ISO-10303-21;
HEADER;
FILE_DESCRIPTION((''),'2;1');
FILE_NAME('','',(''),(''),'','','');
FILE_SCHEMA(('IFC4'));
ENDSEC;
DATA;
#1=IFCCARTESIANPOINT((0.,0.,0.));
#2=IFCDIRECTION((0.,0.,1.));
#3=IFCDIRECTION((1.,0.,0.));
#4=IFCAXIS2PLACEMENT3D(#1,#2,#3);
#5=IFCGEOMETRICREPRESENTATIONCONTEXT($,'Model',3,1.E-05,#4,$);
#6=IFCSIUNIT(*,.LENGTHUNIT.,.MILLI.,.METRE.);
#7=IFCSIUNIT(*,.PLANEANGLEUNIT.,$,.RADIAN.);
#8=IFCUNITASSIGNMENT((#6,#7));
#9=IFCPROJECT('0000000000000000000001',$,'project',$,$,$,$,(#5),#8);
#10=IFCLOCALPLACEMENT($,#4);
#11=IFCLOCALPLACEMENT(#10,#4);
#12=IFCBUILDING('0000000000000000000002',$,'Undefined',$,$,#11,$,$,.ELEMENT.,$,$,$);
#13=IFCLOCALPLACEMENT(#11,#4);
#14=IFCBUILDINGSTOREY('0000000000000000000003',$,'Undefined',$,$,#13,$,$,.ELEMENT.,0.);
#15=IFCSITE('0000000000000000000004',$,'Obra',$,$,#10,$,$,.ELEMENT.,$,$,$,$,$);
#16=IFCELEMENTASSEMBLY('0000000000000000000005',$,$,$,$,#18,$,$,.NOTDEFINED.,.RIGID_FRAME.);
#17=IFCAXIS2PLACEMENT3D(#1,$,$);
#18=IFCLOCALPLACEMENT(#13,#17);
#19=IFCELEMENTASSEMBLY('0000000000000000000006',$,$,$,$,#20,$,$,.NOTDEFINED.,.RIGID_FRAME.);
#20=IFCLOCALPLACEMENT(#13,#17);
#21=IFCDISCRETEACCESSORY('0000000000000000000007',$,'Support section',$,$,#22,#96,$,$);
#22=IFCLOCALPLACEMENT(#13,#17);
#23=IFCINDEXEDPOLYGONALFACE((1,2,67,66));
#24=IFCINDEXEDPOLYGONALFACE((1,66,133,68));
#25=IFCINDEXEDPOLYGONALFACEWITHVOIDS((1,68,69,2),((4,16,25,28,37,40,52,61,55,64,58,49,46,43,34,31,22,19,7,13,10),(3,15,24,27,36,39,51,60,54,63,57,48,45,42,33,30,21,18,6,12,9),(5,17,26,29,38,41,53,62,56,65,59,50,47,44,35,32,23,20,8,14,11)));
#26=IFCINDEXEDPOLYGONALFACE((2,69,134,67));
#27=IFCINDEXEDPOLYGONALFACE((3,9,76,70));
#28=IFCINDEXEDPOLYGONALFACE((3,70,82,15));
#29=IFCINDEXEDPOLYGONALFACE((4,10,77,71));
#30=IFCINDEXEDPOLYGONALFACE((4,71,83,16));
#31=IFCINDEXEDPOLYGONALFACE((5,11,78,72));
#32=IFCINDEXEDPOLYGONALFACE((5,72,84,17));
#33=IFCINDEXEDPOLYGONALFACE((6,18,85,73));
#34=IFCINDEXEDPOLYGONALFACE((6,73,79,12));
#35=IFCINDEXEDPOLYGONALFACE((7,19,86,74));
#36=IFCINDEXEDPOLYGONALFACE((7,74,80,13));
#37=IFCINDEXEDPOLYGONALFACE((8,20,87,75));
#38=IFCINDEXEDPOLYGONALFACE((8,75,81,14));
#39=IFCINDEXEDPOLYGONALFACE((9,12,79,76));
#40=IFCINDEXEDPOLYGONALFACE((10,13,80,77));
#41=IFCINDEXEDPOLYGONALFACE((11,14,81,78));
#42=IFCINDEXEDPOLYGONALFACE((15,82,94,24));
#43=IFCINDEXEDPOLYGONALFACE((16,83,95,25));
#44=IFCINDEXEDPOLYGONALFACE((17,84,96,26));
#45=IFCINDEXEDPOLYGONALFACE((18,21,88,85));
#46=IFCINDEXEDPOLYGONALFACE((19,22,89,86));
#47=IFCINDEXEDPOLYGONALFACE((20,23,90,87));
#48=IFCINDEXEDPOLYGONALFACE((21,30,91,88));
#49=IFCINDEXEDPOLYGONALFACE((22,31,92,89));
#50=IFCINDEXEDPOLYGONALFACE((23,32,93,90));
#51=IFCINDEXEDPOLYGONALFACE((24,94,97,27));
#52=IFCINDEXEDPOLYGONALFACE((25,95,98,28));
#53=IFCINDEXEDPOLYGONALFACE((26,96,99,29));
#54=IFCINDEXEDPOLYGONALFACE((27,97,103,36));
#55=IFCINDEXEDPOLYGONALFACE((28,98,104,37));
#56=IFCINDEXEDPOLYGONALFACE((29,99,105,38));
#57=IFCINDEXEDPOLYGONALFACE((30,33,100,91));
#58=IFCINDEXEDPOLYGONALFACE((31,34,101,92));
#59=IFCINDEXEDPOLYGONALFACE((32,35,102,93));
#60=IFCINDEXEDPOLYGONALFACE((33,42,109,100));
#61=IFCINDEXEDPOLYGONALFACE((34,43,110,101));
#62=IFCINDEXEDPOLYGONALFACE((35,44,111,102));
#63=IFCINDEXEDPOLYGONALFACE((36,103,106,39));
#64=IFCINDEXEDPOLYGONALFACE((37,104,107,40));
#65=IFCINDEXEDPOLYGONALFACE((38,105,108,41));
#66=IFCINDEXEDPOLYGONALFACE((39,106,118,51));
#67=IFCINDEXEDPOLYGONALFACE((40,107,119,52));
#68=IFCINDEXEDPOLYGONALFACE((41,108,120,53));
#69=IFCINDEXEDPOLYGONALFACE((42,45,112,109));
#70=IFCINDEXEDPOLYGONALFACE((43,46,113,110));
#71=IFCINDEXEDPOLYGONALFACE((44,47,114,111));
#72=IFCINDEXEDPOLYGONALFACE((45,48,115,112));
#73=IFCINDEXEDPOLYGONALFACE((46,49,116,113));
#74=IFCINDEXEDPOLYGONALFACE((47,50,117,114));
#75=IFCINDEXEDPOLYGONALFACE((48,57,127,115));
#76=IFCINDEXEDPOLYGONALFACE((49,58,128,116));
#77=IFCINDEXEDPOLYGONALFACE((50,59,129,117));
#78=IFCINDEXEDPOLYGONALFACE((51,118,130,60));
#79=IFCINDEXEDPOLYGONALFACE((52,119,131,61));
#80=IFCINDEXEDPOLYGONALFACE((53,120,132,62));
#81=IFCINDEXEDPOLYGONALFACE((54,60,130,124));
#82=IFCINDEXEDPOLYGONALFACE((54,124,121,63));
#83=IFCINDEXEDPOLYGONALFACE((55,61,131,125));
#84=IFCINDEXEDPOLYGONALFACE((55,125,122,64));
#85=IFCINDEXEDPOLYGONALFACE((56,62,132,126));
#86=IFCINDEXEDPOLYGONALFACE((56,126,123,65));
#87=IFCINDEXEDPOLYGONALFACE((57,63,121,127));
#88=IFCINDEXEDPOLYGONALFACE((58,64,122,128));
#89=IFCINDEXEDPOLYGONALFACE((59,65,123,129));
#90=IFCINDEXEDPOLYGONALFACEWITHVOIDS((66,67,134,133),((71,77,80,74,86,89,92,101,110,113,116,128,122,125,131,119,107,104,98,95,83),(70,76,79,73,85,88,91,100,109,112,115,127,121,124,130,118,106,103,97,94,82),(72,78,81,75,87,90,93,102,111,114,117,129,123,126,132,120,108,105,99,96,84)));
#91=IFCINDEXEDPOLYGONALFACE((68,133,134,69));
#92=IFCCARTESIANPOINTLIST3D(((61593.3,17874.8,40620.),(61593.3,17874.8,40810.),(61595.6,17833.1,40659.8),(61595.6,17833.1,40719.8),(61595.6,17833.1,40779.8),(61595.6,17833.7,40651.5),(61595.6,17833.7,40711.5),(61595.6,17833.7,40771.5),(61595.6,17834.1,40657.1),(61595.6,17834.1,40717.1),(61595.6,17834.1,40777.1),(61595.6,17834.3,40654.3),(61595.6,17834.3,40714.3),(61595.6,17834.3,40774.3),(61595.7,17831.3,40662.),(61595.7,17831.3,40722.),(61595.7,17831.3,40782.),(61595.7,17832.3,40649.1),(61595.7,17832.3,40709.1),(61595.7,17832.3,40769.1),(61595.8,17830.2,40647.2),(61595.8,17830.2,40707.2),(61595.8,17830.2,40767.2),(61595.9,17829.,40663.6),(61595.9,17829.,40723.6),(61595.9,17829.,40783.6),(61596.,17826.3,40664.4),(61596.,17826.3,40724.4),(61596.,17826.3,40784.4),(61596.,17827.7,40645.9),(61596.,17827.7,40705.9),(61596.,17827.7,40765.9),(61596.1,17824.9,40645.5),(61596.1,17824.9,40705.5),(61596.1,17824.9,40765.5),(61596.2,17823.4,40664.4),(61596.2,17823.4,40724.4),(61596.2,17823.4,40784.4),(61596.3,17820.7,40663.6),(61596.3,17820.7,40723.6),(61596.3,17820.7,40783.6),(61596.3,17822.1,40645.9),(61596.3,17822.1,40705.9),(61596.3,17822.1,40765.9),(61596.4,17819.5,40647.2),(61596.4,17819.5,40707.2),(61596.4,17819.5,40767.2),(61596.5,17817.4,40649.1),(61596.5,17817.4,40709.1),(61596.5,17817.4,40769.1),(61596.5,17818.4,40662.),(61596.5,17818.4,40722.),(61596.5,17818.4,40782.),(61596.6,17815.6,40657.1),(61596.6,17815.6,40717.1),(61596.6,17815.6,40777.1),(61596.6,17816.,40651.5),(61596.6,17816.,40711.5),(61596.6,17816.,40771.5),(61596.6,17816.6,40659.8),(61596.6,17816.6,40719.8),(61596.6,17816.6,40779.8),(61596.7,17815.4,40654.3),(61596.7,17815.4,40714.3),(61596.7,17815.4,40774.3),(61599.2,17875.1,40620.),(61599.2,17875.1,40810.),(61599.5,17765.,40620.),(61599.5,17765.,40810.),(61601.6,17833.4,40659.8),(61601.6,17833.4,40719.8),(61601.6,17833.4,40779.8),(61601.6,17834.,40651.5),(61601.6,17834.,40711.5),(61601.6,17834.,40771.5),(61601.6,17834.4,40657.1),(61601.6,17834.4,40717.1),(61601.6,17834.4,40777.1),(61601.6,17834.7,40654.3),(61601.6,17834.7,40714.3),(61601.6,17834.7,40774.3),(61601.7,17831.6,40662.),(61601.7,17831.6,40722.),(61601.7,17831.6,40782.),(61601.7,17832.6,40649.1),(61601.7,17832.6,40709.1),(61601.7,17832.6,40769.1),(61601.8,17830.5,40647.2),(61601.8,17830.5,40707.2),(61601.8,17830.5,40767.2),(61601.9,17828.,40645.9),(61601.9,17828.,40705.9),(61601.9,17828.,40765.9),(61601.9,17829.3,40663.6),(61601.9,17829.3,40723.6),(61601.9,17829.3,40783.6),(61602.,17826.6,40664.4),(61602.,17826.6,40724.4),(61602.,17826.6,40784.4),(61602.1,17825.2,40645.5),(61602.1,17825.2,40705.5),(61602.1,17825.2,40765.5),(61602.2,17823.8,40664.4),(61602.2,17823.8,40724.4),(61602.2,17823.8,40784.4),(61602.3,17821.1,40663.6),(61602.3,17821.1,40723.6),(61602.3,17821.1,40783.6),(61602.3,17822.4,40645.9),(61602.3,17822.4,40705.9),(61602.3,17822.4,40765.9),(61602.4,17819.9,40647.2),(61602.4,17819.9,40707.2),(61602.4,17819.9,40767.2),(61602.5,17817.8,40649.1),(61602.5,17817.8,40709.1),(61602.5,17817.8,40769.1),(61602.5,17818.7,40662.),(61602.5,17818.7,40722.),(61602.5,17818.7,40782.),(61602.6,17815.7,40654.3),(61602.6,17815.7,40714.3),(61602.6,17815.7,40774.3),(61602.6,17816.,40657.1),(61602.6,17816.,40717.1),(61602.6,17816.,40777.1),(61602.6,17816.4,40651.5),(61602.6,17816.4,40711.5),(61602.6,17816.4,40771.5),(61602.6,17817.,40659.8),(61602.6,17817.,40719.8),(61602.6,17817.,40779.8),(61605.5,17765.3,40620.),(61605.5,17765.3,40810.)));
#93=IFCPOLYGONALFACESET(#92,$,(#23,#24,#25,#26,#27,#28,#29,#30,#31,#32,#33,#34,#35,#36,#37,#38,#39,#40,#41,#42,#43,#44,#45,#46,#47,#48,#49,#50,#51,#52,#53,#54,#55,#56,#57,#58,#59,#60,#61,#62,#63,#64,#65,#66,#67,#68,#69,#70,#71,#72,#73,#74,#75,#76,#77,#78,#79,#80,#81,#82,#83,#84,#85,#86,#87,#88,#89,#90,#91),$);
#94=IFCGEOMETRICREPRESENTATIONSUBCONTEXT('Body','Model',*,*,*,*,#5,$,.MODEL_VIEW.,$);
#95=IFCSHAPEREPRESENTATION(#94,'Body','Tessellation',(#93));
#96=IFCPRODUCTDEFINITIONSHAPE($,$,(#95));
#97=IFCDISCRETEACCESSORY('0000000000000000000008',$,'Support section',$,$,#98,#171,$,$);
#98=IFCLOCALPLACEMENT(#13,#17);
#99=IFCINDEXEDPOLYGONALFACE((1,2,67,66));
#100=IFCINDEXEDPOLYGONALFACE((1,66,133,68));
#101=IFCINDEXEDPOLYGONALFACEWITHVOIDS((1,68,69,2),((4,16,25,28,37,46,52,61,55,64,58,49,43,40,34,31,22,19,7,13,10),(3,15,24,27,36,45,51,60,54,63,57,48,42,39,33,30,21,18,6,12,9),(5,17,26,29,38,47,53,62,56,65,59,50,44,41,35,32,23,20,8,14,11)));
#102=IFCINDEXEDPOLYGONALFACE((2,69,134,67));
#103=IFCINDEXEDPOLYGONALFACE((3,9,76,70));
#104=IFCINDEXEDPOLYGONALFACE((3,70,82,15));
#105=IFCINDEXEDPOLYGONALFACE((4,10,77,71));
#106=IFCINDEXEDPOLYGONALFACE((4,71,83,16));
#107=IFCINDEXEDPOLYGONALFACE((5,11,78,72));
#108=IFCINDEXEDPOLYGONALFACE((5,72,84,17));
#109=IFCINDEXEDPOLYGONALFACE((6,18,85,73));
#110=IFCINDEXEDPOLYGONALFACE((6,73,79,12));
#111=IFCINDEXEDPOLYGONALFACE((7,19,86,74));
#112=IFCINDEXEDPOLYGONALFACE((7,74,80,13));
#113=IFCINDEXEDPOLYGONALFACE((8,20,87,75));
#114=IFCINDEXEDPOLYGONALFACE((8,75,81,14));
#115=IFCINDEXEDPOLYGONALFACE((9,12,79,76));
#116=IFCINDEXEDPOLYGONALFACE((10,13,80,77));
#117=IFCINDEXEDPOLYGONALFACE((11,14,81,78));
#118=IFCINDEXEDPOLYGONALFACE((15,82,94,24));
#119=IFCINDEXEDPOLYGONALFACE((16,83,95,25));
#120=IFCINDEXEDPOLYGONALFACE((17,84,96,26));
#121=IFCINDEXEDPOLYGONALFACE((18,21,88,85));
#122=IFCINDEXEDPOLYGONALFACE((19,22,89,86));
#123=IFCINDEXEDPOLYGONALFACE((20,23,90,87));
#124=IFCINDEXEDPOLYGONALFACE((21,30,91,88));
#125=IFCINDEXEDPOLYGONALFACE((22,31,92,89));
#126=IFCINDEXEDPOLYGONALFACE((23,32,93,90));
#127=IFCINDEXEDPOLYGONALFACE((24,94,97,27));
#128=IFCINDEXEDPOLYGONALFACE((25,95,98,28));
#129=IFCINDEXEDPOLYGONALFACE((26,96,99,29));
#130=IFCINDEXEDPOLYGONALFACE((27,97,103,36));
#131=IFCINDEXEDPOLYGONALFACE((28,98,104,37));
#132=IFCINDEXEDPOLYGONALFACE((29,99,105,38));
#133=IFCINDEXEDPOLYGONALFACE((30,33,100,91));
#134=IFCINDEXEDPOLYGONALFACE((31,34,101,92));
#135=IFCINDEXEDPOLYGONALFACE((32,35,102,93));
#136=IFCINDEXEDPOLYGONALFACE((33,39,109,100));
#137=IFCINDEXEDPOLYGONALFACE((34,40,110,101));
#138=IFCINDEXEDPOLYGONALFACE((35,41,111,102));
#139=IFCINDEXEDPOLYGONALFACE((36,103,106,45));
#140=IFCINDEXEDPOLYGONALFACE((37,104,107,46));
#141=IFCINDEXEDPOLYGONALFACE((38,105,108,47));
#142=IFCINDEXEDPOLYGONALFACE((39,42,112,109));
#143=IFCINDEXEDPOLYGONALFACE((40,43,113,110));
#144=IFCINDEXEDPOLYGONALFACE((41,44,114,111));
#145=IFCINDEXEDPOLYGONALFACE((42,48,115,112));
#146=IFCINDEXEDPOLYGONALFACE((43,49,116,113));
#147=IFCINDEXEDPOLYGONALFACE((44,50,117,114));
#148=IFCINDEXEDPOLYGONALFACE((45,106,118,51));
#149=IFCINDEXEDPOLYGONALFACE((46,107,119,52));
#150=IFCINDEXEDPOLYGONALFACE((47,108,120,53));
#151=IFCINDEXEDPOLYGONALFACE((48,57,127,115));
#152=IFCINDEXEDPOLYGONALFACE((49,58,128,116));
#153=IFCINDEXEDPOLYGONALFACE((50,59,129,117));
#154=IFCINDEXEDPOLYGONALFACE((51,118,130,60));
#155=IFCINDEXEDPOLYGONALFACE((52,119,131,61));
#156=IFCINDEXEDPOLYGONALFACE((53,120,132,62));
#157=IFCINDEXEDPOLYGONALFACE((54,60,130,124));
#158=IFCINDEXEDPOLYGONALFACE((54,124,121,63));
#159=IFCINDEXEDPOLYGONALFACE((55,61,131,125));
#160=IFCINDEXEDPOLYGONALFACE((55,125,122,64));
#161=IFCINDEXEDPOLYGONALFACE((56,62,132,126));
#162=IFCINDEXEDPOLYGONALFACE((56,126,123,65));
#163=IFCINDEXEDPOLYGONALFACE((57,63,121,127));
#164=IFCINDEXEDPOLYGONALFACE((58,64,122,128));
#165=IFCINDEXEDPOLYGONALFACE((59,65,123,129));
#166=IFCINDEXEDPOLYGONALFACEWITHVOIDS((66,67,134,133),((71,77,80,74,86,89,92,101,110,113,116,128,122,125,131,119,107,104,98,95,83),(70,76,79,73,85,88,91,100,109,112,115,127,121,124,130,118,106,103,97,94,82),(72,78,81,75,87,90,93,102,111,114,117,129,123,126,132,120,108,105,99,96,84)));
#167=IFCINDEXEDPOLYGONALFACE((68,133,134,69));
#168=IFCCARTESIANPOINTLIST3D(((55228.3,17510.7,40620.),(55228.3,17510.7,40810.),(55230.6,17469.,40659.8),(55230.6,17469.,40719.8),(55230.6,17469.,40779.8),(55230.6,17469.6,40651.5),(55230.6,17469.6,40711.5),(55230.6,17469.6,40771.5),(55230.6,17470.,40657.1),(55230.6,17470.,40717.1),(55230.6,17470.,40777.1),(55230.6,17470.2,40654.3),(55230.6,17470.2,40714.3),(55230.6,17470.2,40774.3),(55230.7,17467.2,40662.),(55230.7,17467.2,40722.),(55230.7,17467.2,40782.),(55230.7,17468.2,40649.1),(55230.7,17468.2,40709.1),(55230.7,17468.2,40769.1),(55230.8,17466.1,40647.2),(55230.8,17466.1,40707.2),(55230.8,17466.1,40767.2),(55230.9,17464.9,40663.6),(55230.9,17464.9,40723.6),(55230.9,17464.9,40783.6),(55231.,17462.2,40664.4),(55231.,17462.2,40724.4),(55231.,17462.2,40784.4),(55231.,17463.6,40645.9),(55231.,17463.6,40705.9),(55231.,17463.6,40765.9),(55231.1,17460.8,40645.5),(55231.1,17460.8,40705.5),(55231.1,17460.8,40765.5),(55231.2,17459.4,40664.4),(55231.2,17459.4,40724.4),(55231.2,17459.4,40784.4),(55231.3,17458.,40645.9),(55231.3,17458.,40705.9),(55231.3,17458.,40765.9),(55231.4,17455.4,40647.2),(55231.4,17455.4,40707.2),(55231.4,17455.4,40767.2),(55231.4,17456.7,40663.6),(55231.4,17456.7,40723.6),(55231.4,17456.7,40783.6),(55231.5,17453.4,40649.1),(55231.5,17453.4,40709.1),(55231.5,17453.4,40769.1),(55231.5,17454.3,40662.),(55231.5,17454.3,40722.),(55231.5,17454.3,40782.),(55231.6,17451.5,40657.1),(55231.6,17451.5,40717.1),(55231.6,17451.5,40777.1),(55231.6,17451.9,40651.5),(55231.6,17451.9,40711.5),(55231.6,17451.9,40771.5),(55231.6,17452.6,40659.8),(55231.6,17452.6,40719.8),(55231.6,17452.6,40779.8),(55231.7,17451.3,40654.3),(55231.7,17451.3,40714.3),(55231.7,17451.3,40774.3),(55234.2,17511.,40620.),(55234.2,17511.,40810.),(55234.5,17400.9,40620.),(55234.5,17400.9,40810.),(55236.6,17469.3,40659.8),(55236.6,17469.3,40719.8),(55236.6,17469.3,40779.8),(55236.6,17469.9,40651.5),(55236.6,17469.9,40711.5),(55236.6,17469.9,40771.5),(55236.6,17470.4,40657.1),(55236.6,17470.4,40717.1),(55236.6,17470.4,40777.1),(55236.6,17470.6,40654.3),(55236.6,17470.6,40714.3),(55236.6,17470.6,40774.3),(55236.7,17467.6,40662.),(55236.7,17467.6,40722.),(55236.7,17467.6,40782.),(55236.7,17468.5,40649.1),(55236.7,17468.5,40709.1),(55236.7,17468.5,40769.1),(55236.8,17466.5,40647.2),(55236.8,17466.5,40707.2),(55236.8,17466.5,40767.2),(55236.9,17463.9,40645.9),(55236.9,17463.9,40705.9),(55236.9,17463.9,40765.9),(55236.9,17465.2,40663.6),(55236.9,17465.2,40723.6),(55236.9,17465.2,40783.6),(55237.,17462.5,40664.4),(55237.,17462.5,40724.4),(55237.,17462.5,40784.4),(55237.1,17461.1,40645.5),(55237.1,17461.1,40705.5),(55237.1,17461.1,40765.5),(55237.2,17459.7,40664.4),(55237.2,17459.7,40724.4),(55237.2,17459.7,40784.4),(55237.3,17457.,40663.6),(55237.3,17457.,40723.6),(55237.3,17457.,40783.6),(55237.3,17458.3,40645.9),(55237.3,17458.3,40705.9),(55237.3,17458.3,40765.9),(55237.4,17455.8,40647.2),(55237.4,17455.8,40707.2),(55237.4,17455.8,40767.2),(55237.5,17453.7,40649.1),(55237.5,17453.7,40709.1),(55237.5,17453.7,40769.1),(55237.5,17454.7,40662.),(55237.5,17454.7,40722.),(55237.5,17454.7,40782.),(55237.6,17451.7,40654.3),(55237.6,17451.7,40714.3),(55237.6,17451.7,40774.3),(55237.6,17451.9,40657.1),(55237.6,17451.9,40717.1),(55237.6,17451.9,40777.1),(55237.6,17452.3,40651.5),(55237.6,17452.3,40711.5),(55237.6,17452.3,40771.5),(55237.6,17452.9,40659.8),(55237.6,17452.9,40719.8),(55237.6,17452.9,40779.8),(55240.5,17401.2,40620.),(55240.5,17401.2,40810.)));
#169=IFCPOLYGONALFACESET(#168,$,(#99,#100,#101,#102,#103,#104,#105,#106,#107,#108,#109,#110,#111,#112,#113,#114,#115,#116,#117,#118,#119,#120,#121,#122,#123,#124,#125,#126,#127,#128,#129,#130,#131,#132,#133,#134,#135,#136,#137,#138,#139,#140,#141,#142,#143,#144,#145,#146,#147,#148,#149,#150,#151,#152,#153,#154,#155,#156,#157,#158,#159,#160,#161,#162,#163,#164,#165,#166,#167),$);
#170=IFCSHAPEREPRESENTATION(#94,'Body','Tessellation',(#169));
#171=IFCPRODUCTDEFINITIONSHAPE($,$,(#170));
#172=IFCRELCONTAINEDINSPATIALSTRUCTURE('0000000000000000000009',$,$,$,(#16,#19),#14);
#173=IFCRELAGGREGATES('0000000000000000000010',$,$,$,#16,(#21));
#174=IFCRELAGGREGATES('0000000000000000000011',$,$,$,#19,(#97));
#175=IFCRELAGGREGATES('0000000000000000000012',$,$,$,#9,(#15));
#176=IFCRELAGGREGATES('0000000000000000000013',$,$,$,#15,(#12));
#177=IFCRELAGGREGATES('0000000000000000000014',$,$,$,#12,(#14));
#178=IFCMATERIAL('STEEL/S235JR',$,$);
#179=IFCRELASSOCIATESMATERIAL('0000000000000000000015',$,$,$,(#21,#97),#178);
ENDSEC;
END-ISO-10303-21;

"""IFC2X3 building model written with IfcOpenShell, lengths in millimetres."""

from ifc_helpers import new_model, si_unit, frame, origin_with_axes, origin_2d_with_axis, place, context, subcontext, project, spatial, rectangle, circle, extrude, source, transform, mapped, material, element, aggregate, save


model = new_model("IFC2X3")

# Units and contexts
model_context = context("Model", 3, precision=1e-05, world=origin_with_axes())
body_context = subcontext(model_context, "Body", "Model", "MODEL_VIEW")
ifc_project = project(units=[si_unit("LENGTHUNIT", "METRE", prefix="MILLI"), si_unit("PLANEANGLEUNIT", "RADIAN")], contexts=[model_context])

# Site, building, storey
site_placement = place(None, origin_with_axes())
site = spatial("IfcSite", under=ifc_project, at=site_placement, Name="Obra", CompositionType="ELEMENT")
building_placement = place(site_placement, origin_with_axes())
building = spatial("IfcBuilding", under=site, at=building_placement, Name="Undefined", CompositionType="ELEMENT")
storey_placement = place(building_placement, origin_with_axes())
storey = spatial("IfcBuildingStorey", under=building, at=storey_placement, Name="Undefined", CompositionType="ELEMENT", Elevation=0.0)

# Element assemblies
assembly_1_placement = place(storey_placement, origin_with_axes())
assembly_1 = element("IfcElementAssembly", 1, at=assembly_1_placement, inside=storey, AssemblyPlace="NOTDEFINED", PredefinedType="RIGID_FRAME")
ifc_material_1 = material(Name="STEEL/S235JR")
assembly_2_placement = place(storey_placement, origin_with_axes())
assembly_2 = element("IfcElementAssembly", 2, at=assembly_2_placement, inside=storey, AssemblyPlace="NOTDEFINED", PredefinedType="RIGID_FRAME")

# Discrete accessories, openings
discrete_accessory_1_placement = place(assembly_1_placement, frame((61599.4, 17820.0, 40620.0), z_axis=(0.0, 0.0, 1.0), x_axis=(0.057107, -0.998368, 0.0)))
discrete_accessory_1 = element("IfcDiscreteAccessory", 3, at=discrete_accessory_1_placement, material=ifc_material_1, Name="Support section", context=body_context, shape_type="SweptSolid", body=[
    extrude(rectangle(XDim=6.0, YDim=110.0, at=origin_2d_with_axis()), frame((0.0, 0.0, 190.0), z_axis=(0.0, 0.0, -1.0), x_axis=(0.0, 1.0, 0.0)), (0.0, 0.0, 1.0), 190.0),
])
shared_shape_1 = source(origin_with_axes(), body_context, "Body", "SweptSolid", [
    extrude(circle(Radius=9.5, at=origin_2d_with_axis()), frame((0.0, -9.2, 0.0), z_axis=(0.0, 1.0, 0.0), x_axis=(1.0, 0.0, 0.0)), (0.0, 0.0, 1.0), 6.2),
])
opening_1_placement = place(assembly_1_placement, frame((61595.9, 17774.8, 40835.0), z_axis=(-0.057107, 0.998368, 0.0), x_axis=(0.0, 0.0, -1.0)))
element("IfcOpeningElement", 4, at=opening_1_placement, cuts=discrete_accessory_1, ObjectType="Opening", context=body_context, shape_type="MappedRepresentation", body=[
    mapped(shared_shape_1, transform((60.0, 0.0, 50.0))),
    mapped(shared_shape_1, transform((120.0, 0.0, 50.0))),
    mapped(shared_shape_1, transform((180.0, 0.0, 50.0))),
])
aggregate(assembly_1, [discrete_accessory_1])
discrete_accessory_2_placement = place(assembly_2_placement, frame((55234.4, 17456.0, 40620.0), z_axis=(0.0, 0.0, 1.0), x_axis=(0.057107, -0.998368, 0.0)))
discrete_accessory_2 = element("IfcDiscreteAccessory", 5, at=discrete_accessory_2_placement, material=ifc_material_1, Name="Support section", context=body_context, shape_type="SweptSolid", body=[
    extrude(rectangle(XDim=6.0, YDim=110.0, at=origin_2d_with_axis()), frame((0.0, 0.0, 190.0), z_axis=(0.0, 0.0, -1.0), x_axis=(0.0, 1.0, 0.0)), (0.0, 0.0, 1.0), 190.0),
])
opening_2_placement = place(assembly_2_placement, frame((55230.9, 17410.7, 40835.0), z_axis=(-0.057107, 0.998368, 0.0), x_axis=(0.0, 0.0, -1.0)))
element("IfcOpeningElement", 6, at=opening_2_placement, cuts=discrete_accessory_2, ObjectType="Opening", context=body_context, shape_type="MappedRepresentation", body=[
    mapped(shared_shape_1, transform((60.0, 0.0, 50.0))),
    mapped(shared_shape_1, transform((120.0, 0.0, 50.0))),
    mapped(shared_shape_1, transform((180.0, 0.0, 50.0))),
])
aggregate(assembly_2, [discrete_accessory_2])

save(model, "model.ifc")
